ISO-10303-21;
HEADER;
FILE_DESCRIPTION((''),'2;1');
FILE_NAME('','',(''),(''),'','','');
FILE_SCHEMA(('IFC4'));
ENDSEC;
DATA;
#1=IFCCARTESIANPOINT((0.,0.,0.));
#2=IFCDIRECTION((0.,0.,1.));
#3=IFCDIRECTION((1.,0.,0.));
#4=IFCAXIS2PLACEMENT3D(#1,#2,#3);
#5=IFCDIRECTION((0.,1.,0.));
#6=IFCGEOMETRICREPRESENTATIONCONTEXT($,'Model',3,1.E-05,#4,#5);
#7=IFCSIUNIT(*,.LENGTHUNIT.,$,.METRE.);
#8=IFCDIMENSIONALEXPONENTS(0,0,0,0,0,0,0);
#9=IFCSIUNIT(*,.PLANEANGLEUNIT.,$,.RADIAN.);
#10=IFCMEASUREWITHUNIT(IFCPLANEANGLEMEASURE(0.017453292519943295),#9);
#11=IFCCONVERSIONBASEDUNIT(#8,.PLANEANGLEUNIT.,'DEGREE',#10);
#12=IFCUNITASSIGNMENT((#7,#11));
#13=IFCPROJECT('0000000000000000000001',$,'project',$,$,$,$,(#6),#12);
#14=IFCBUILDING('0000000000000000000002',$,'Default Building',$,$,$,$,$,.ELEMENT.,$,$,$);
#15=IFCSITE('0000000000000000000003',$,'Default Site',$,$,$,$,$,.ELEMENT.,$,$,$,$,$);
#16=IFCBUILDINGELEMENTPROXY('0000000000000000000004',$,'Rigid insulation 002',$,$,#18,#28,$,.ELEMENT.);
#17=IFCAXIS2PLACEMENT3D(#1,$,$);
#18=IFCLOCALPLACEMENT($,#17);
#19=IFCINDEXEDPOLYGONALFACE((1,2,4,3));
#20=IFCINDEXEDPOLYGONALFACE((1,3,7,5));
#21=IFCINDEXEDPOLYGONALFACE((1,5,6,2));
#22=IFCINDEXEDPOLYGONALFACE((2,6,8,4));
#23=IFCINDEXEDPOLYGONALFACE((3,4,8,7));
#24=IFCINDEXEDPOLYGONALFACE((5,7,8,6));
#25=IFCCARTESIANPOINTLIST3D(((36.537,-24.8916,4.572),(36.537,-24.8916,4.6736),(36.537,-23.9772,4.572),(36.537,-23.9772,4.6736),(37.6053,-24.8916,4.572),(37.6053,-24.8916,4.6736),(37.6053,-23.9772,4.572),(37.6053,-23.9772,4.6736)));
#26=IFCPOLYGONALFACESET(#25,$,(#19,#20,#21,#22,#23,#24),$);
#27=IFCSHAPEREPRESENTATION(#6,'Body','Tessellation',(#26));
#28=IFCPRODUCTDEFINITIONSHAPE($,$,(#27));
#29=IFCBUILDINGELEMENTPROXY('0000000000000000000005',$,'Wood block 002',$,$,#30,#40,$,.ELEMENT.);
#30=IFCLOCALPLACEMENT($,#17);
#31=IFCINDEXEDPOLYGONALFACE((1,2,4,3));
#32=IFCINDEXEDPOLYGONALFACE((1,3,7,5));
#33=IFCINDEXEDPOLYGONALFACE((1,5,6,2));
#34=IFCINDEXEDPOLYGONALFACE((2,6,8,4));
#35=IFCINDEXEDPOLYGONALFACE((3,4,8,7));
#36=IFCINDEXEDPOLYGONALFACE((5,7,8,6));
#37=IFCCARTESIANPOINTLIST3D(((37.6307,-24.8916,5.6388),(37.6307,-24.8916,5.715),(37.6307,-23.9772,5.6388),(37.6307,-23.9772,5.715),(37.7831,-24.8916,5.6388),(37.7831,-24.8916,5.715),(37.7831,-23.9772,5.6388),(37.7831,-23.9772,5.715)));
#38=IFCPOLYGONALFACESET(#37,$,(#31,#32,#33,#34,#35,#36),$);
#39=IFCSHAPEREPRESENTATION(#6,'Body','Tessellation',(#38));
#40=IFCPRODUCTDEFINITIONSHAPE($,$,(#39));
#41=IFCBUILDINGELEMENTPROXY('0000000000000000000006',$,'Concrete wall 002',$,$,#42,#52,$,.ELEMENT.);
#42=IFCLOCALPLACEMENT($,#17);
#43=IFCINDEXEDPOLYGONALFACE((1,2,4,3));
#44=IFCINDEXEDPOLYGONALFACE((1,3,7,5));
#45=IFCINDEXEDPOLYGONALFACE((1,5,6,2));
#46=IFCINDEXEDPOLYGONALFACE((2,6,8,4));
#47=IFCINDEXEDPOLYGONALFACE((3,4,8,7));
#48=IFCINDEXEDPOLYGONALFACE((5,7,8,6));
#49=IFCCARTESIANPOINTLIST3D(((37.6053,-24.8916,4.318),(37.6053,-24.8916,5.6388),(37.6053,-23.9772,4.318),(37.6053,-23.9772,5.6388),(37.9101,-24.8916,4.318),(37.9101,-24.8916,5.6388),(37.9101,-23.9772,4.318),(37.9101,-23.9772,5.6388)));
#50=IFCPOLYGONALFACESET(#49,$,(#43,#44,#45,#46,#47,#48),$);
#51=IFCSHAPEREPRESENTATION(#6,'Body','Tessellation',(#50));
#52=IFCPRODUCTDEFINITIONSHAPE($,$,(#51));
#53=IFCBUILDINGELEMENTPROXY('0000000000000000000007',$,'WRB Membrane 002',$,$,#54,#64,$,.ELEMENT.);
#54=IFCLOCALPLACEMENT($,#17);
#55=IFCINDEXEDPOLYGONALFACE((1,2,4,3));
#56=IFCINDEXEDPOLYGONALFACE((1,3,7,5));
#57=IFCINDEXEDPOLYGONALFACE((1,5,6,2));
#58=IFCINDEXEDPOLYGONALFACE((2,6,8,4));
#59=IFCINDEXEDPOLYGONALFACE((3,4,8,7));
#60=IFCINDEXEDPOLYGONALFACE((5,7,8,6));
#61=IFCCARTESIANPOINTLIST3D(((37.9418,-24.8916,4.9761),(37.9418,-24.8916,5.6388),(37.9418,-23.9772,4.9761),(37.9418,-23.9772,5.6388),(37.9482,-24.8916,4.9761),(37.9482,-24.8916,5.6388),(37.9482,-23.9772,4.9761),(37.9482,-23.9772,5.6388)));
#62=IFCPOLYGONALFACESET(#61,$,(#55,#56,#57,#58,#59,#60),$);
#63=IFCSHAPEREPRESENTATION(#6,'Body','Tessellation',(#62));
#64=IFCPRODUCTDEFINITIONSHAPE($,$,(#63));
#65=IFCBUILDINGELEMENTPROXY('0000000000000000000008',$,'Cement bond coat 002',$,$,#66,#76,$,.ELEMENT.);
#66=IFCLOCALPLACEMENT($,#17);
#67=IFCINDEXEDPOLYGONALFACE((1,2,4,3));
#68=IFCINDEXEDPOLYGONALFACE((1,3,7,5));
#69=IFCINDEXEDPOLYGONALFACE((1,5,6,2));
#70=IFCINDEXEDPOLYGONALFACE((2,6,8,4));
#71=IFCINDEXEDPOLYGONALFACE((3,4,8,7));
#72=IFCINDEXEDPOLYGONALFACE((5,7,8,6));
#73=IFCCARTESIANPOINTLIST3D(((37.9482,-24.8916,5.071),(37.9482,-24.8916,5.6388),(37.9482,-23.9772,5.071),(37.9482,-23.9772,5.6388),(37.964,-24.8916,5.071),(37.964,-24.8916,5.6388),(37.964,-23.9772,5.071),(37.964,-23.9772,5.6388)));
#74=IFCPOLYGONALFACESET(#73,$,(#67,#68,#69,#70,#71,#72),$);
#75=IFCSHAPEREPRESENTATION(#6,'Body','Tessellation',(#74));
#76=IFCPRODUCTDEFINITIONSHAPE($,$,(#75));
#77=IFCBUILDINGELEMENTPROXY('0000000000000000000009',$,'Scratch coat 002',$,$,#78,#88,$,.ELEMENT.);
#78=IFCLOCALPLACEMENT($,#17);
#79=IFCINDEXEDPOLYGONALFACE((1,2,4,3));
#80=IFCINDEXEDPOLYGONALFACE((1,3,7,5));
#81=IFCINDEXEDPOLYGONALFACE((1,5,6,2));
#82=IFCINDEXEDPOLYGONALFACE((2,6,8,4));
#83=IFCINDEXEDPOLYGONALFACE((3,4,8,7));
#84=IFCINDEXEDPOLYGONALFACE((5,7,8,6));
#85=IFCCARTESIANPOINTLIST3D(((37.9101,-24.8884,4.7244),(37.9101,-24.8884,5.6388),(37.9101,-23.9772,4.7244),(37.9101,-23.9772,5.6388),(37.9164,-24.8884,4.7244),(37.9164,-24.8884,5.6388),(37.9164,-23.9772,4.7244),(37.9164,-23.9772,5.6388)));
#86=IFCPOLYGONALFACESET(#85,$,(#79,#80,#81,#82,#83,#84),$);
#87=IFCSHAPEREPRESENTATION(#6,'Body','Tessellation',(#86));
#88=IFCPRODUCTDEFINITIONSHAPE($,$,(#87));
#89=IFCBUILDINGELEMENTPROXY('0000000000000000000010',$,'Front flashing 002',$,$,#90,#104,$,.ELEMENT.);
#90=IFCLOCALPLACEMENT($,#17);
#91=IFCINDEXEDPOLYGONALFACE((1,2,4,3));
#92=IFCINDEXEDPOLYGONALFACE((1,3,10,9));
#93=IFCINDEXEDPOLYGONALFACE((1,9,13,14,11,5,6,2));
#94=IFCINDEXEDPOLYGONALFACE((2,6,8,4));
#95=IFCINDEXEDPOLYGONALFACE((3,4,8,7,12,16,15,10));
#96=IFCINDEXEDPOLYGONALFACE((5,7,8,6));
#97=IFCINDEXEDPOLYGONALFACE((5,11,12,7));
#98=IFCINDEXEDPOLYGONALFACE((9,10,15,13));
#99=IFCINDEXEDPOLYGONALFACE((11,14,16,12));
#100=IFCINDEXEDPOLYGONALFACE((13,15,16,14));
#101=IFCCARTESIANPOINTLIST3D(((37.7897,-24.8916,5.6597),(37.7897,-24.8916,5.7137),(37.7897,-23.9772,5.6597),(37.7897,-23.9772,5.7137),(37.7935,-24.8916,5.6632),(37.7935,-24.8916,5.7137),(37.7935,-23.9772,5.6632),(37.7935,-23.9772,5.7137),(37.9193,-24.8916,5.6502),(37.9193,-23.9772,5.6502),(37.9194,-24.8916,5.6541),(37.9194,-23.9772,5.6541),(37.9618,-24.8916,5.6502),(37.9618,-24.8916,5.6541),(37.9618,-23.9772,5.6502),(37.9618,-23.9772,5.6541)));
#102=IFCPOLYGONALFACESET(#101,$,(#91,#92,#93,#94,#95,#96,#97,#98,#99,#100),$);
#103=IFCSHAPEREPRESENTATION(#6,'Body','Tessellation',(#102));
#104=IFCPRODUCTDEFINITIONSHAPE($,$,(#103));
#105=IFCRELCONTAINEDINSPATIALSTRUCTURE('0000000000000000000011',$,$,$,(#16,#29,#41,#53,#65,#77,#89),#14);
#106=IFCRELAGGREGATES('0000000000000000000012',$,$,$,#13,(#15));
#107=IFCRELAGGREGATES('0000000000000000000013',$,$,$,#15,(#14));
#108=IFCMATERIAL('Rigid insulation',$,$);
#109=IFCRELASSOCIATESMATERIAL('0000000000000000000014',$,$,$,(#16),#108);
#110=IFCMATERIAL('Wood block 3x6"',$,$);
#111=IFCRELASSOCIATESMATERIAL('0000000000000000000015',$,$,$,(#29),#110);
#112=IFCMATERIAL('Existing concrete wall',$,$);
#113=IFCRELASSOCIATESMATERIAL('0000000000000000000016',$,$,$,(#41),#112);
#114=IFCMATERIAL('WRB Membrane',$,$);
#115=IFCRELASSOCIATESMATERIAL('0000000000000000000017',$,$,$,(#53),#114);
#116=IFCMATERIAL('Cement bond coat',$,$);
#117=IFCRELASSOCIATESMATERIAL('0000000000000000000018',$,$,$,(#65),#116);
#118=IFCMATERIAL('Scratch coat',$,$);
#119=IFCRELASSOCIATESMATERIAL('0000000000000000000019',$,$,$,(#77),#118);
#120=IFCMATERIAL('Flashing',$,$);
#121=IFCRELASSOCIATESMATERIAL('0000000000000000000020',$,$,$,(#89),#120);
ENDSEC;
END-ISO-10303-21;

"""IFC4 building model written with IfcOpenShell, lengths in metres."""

from ifc_helpers import new_model, entity, si_unit, converted_unit, direction, frame, origin_with_axes, place, context, project, spatial, polyline, outline, extrude, source, transform, mapped, material, element, save


model = new_model("IFC4")

# Units and contexts
model_context = context("Model", 3, precision=1e-05, world=origin_with_axes(), true_north=direction((0.0, 1.0, 0.0)))
ifc_project = project(units=[si_unit("LENGTHUNIT", "METRE"), converted_unit("PLANEANGLEUNIT", "DEGREE", entity("IfcPlaneAngleMeasure", 0.017453292519943295), si_unit("PLANEANGLEUNIT", "RADIAN"), dimensions=[0, 0, 0, 0, 0, 0, 0])], contexts=[model_context])

# Site, building
site = spatial("IfcSite", under=ifc_project, Name="Default Site", CompositionType="ELEMENT")
building = spatial("IfcBuilding", under=site, Name="Default Building", CompositionType="ELEMENT")

# Building element proxies
ifc_material_1 = material(Name="Rigid insulation")
shared_shape_1 = source(origin_with_axes(), model_context, "Body", "SweptSolid", [
    extrude(outline(polyline([(-0.5342, -0.0508), (0.5342, -0.0508), (0.5342, 0.0508), (-0.5342, 0.0508), (-0.5342, -0.0508)])), frame((36.4077, 4.6228, 0.0), z_axis=(0.0, 0.0, 1.0), x_axis=(1.0, 0.0, 0.0)), (0.0, 0.0, 1.0), 0.9144),
])
proxy_1_placement = place(None, origin_with_axes())
element("IfcBuildingElementProxy", 1, at=proxy_1_placement, inside=building, material=ifc_material_1, Name="Rigid insulation 002", PredefinedType="ELEMENT", context=model_context, shape_type="MappedRepresentation", body=[
    mapped(shared_shape_1, transform((0.6635, -23.9772, 0.0), x_axis=(1.0, 0.0, 0.0), y_axis=(0.0, 0.0, 1.0), z_axis=(0.0, -1.0, 0.0), scale=1.0)),
])
ifc_material_2 = material(Name="Wood block 3x6\"")
shared_shape_2 = source(origin_with_axes(), model_context, "Body", "SweptSolid", [
    extrude(outline(polyline([(-0.0762, -0.0381), (0.0762, -0.0381), (0.0762, 0.0381), (-0.0762, 0.0381), (-0.0762, -0.0381)])), frame((37.0434, 5.6769, 0.0), z_axis=(0.0, 0.0, 1.0), x_axis=(1.0, 0.0, 0.0)), (0.0, 0.0, 1.0), 0.9144),
])
proxy_2_placement = place(None, origin_with_axes())
element("IfcBuildingElementProxy", 2, at=proxy_2_placement, inside=building, material=ifc_material_2, Name="Wood block 002", PredefinedType="ELEMENT", context=model_context, shape_type="MappedRepresentation", body=[
    mapped(shared_shape_2, transform((0.6635, -23.9772, 0.0), x_axis=(1.0, 0.0, 0.0), y_axis=(0.0, 0.0, 1.0), z_axis=(0.0, -1.0, 0.0), scale=1.0)),
])
ifc_material_3 = material(Name="Existing concrete wall")
shared_shape_3 = source(origin_with_axes(), model_context, "Body", "SweptSolid", [
    extrude(outline(polyline([(-0.1524, -0.6604), (0.1524, -0.6604), (0.1524, 0.6604), (-0.1524, 0.6604), (-0.1524, -0.6604)])), frame((37.0942, 5.1816, 0.0), z_axis=(0.0, 0.0, 1.0), x_axis=(1.0, 0.0, 0.0)), (0.0, 0.0, 1.0), 0.9144),
])
proxy_3_placement = place(None, origin_with_axes())
element("IfcBuildingElementProxy", 3, at=proxy_3_placement, inside=building, material=ifc_material_3, Name="Concrete wall 002", PredefinedType="ELEMENT", context=model_context, shape_type="MappedRepresentation", body=[
    mapped(shared_shape_3, transform((0.6635, -23.9772, -0.2032), x_axis=(1.0, 0.0, 0.0), y_axis=(0.0, 0.0, 1.0), z_axis=(0.0, -1.0, 0.0), scale=1.0)),
])
ifc_material_4 = material(Name="WRB Membrane")
shared_shape_4 = source(origin_with_axes(), model_context, "Body", "SweptSolid", [
    extrude(outline(polyline([(-0.0032, -0.3313), (0.0032, -0.3313), (0.0032, 0.3313), (-0.0032, 0.3313), (-0.0032, -0.3313)])), frame((37.2815, 5.3075, 0.0), z_axis=(0.0, 0.0, 1.0), x_axis=(1.0, 0.0, 0.0)), (0.0, 0.0, 1.0), 0.9144),
])
proxy_4_placement = place(None, origin_with_axes())
element("IfcBuildingElementProxy", 4, at=proxy_4_placement, inside=building, material=ifc_material_4, Name="WRB Membrane 002", PredefinedType="ELEMENT", context=model_context, shape_type="MappedRepresentation", body=[
    mapped(shared_shape_4, transform((0.6635, -23.9772, 0.0), x_axis=(1.0, 0.0, 0.0), y_axis=(0.0, 0.0, 1.0), z_axis=(0.0, -1.0, 0.0), scale=1.0)),
])
ifc_material_5 = material(Name="Cement bond coat")
shared_shape_5 = source(origin_with_axes(), model_context, "Body", "SweptSolid", [
    extrude(outline(polyline([(-0.0079, -0.2839), (0.0079, -0.2839), (0.0079, 0.2839), (-0.0079, 0.2839), (-0.0079, -0.2839)])), frame((37.2927, 5.3549, 0.0), z_axis=(0.0, 0.0, 1.0), x_axis=(1.0, 0.0, 0.0)), (0.0, 0.0, 1.0), 0.9144),
])
proxy_5_placement = place(None, origin_with_axes())
element("IfcBuildingElementProxy", 5, at=proxy_5_placement, inside=building, material=ifc_material_5, Name="Cement bond coat 002", PredefinedType="ELEMENT", context=model_context, shape_type="MappedRepresentation", body=[
    mapped(shared_shape_5, transform((0.6635, -23.9772, 0.0), x_axis=(1.0, 0.0, 0.0), y_axis=(0.0, 0.0, 1.0), z_axis=(0.0, -1.0, 0.0), scale=1.0)),
])
ifc_material_6 = material(Name="Scratch coat")
shared_shape_6 = source(origin_with_axes(), model_context, "Body", "SweptSolid", [
    extrude(outline(polyline([(-0.0032, 0.4572), (0.0032, 0.4572), (0.0032, -0.4572), (-0.0032, -0.4572), (-0.0032, 0.4572)])), frame((37.2498, 5.1816, 0.0), z_axis=(0.0, 0.0, 1.0), x_axis=(1.0, 0.0, 0.0)), (0.0, 0.0, 1.0), 0.9112),
])
proxy_6_placement = place(None, origin_with_axes())
element("IfcBuildingElementProxy", 6, at=proxy_6_placement, inside=building, material=ifc_material_6, Name="Scratch coat 002", PredefinedType="ELEMENT", context=model_context, shape_type="MappedRepresentation", body=[
    mapped(shared_shape_6, transform((0.6635, -23.9772, 0.0), x_axis=(1.0, 0.0, 0.0), y_axis=(0.0, 0.0, 1.0), z_axis=(0.0, -1.0, 0.0), scale=1.0)),
])
ifc_material_7 = material(Name="Flashing")
shared_shape_7 = source(origin_with_axes(), model_context, "Body", "SweptSolid", [
    extrude(outline(polyline([(0.0627, -0.0091), (-0.0632, 0.0001), (-0.0632, 0.0506), (-0.067, 0.0506), (-0.067, -0.0035), (0.0625, -0.0129), (0.1051, -0.0129), (0.1051, -0.0091), (0.0627, -0.0091)])), frame((37.1933, 5.6631, 0.0), z_axis=(0.0, 0.0, 1.0), x_axis=(1.0, 0.0, 0.0)), (0.0, 0.0, 1.0), 0.9144),
])
proxy_7_placement = place(None, origin_with_axes())
element("IfcBuildingElementProxy", 7, at=proxy_7_placement, inside=building, material=ifc_material_7, Name="Front flashing 002", PredefinedType="ELEMENT", context=model_context, shape_type="MappedRepresentation", body=[
    mapped(shared_shape_7, transform((0.6635, -23.9772, 0.0), x_axis=(1.0, 0.0, 0.0), y_axis=(0.0, 0.0, 1.0), z_axis=(0.0, -1.0, 0.0), scale=1.0)),
])

save(model, "model.ifc")
